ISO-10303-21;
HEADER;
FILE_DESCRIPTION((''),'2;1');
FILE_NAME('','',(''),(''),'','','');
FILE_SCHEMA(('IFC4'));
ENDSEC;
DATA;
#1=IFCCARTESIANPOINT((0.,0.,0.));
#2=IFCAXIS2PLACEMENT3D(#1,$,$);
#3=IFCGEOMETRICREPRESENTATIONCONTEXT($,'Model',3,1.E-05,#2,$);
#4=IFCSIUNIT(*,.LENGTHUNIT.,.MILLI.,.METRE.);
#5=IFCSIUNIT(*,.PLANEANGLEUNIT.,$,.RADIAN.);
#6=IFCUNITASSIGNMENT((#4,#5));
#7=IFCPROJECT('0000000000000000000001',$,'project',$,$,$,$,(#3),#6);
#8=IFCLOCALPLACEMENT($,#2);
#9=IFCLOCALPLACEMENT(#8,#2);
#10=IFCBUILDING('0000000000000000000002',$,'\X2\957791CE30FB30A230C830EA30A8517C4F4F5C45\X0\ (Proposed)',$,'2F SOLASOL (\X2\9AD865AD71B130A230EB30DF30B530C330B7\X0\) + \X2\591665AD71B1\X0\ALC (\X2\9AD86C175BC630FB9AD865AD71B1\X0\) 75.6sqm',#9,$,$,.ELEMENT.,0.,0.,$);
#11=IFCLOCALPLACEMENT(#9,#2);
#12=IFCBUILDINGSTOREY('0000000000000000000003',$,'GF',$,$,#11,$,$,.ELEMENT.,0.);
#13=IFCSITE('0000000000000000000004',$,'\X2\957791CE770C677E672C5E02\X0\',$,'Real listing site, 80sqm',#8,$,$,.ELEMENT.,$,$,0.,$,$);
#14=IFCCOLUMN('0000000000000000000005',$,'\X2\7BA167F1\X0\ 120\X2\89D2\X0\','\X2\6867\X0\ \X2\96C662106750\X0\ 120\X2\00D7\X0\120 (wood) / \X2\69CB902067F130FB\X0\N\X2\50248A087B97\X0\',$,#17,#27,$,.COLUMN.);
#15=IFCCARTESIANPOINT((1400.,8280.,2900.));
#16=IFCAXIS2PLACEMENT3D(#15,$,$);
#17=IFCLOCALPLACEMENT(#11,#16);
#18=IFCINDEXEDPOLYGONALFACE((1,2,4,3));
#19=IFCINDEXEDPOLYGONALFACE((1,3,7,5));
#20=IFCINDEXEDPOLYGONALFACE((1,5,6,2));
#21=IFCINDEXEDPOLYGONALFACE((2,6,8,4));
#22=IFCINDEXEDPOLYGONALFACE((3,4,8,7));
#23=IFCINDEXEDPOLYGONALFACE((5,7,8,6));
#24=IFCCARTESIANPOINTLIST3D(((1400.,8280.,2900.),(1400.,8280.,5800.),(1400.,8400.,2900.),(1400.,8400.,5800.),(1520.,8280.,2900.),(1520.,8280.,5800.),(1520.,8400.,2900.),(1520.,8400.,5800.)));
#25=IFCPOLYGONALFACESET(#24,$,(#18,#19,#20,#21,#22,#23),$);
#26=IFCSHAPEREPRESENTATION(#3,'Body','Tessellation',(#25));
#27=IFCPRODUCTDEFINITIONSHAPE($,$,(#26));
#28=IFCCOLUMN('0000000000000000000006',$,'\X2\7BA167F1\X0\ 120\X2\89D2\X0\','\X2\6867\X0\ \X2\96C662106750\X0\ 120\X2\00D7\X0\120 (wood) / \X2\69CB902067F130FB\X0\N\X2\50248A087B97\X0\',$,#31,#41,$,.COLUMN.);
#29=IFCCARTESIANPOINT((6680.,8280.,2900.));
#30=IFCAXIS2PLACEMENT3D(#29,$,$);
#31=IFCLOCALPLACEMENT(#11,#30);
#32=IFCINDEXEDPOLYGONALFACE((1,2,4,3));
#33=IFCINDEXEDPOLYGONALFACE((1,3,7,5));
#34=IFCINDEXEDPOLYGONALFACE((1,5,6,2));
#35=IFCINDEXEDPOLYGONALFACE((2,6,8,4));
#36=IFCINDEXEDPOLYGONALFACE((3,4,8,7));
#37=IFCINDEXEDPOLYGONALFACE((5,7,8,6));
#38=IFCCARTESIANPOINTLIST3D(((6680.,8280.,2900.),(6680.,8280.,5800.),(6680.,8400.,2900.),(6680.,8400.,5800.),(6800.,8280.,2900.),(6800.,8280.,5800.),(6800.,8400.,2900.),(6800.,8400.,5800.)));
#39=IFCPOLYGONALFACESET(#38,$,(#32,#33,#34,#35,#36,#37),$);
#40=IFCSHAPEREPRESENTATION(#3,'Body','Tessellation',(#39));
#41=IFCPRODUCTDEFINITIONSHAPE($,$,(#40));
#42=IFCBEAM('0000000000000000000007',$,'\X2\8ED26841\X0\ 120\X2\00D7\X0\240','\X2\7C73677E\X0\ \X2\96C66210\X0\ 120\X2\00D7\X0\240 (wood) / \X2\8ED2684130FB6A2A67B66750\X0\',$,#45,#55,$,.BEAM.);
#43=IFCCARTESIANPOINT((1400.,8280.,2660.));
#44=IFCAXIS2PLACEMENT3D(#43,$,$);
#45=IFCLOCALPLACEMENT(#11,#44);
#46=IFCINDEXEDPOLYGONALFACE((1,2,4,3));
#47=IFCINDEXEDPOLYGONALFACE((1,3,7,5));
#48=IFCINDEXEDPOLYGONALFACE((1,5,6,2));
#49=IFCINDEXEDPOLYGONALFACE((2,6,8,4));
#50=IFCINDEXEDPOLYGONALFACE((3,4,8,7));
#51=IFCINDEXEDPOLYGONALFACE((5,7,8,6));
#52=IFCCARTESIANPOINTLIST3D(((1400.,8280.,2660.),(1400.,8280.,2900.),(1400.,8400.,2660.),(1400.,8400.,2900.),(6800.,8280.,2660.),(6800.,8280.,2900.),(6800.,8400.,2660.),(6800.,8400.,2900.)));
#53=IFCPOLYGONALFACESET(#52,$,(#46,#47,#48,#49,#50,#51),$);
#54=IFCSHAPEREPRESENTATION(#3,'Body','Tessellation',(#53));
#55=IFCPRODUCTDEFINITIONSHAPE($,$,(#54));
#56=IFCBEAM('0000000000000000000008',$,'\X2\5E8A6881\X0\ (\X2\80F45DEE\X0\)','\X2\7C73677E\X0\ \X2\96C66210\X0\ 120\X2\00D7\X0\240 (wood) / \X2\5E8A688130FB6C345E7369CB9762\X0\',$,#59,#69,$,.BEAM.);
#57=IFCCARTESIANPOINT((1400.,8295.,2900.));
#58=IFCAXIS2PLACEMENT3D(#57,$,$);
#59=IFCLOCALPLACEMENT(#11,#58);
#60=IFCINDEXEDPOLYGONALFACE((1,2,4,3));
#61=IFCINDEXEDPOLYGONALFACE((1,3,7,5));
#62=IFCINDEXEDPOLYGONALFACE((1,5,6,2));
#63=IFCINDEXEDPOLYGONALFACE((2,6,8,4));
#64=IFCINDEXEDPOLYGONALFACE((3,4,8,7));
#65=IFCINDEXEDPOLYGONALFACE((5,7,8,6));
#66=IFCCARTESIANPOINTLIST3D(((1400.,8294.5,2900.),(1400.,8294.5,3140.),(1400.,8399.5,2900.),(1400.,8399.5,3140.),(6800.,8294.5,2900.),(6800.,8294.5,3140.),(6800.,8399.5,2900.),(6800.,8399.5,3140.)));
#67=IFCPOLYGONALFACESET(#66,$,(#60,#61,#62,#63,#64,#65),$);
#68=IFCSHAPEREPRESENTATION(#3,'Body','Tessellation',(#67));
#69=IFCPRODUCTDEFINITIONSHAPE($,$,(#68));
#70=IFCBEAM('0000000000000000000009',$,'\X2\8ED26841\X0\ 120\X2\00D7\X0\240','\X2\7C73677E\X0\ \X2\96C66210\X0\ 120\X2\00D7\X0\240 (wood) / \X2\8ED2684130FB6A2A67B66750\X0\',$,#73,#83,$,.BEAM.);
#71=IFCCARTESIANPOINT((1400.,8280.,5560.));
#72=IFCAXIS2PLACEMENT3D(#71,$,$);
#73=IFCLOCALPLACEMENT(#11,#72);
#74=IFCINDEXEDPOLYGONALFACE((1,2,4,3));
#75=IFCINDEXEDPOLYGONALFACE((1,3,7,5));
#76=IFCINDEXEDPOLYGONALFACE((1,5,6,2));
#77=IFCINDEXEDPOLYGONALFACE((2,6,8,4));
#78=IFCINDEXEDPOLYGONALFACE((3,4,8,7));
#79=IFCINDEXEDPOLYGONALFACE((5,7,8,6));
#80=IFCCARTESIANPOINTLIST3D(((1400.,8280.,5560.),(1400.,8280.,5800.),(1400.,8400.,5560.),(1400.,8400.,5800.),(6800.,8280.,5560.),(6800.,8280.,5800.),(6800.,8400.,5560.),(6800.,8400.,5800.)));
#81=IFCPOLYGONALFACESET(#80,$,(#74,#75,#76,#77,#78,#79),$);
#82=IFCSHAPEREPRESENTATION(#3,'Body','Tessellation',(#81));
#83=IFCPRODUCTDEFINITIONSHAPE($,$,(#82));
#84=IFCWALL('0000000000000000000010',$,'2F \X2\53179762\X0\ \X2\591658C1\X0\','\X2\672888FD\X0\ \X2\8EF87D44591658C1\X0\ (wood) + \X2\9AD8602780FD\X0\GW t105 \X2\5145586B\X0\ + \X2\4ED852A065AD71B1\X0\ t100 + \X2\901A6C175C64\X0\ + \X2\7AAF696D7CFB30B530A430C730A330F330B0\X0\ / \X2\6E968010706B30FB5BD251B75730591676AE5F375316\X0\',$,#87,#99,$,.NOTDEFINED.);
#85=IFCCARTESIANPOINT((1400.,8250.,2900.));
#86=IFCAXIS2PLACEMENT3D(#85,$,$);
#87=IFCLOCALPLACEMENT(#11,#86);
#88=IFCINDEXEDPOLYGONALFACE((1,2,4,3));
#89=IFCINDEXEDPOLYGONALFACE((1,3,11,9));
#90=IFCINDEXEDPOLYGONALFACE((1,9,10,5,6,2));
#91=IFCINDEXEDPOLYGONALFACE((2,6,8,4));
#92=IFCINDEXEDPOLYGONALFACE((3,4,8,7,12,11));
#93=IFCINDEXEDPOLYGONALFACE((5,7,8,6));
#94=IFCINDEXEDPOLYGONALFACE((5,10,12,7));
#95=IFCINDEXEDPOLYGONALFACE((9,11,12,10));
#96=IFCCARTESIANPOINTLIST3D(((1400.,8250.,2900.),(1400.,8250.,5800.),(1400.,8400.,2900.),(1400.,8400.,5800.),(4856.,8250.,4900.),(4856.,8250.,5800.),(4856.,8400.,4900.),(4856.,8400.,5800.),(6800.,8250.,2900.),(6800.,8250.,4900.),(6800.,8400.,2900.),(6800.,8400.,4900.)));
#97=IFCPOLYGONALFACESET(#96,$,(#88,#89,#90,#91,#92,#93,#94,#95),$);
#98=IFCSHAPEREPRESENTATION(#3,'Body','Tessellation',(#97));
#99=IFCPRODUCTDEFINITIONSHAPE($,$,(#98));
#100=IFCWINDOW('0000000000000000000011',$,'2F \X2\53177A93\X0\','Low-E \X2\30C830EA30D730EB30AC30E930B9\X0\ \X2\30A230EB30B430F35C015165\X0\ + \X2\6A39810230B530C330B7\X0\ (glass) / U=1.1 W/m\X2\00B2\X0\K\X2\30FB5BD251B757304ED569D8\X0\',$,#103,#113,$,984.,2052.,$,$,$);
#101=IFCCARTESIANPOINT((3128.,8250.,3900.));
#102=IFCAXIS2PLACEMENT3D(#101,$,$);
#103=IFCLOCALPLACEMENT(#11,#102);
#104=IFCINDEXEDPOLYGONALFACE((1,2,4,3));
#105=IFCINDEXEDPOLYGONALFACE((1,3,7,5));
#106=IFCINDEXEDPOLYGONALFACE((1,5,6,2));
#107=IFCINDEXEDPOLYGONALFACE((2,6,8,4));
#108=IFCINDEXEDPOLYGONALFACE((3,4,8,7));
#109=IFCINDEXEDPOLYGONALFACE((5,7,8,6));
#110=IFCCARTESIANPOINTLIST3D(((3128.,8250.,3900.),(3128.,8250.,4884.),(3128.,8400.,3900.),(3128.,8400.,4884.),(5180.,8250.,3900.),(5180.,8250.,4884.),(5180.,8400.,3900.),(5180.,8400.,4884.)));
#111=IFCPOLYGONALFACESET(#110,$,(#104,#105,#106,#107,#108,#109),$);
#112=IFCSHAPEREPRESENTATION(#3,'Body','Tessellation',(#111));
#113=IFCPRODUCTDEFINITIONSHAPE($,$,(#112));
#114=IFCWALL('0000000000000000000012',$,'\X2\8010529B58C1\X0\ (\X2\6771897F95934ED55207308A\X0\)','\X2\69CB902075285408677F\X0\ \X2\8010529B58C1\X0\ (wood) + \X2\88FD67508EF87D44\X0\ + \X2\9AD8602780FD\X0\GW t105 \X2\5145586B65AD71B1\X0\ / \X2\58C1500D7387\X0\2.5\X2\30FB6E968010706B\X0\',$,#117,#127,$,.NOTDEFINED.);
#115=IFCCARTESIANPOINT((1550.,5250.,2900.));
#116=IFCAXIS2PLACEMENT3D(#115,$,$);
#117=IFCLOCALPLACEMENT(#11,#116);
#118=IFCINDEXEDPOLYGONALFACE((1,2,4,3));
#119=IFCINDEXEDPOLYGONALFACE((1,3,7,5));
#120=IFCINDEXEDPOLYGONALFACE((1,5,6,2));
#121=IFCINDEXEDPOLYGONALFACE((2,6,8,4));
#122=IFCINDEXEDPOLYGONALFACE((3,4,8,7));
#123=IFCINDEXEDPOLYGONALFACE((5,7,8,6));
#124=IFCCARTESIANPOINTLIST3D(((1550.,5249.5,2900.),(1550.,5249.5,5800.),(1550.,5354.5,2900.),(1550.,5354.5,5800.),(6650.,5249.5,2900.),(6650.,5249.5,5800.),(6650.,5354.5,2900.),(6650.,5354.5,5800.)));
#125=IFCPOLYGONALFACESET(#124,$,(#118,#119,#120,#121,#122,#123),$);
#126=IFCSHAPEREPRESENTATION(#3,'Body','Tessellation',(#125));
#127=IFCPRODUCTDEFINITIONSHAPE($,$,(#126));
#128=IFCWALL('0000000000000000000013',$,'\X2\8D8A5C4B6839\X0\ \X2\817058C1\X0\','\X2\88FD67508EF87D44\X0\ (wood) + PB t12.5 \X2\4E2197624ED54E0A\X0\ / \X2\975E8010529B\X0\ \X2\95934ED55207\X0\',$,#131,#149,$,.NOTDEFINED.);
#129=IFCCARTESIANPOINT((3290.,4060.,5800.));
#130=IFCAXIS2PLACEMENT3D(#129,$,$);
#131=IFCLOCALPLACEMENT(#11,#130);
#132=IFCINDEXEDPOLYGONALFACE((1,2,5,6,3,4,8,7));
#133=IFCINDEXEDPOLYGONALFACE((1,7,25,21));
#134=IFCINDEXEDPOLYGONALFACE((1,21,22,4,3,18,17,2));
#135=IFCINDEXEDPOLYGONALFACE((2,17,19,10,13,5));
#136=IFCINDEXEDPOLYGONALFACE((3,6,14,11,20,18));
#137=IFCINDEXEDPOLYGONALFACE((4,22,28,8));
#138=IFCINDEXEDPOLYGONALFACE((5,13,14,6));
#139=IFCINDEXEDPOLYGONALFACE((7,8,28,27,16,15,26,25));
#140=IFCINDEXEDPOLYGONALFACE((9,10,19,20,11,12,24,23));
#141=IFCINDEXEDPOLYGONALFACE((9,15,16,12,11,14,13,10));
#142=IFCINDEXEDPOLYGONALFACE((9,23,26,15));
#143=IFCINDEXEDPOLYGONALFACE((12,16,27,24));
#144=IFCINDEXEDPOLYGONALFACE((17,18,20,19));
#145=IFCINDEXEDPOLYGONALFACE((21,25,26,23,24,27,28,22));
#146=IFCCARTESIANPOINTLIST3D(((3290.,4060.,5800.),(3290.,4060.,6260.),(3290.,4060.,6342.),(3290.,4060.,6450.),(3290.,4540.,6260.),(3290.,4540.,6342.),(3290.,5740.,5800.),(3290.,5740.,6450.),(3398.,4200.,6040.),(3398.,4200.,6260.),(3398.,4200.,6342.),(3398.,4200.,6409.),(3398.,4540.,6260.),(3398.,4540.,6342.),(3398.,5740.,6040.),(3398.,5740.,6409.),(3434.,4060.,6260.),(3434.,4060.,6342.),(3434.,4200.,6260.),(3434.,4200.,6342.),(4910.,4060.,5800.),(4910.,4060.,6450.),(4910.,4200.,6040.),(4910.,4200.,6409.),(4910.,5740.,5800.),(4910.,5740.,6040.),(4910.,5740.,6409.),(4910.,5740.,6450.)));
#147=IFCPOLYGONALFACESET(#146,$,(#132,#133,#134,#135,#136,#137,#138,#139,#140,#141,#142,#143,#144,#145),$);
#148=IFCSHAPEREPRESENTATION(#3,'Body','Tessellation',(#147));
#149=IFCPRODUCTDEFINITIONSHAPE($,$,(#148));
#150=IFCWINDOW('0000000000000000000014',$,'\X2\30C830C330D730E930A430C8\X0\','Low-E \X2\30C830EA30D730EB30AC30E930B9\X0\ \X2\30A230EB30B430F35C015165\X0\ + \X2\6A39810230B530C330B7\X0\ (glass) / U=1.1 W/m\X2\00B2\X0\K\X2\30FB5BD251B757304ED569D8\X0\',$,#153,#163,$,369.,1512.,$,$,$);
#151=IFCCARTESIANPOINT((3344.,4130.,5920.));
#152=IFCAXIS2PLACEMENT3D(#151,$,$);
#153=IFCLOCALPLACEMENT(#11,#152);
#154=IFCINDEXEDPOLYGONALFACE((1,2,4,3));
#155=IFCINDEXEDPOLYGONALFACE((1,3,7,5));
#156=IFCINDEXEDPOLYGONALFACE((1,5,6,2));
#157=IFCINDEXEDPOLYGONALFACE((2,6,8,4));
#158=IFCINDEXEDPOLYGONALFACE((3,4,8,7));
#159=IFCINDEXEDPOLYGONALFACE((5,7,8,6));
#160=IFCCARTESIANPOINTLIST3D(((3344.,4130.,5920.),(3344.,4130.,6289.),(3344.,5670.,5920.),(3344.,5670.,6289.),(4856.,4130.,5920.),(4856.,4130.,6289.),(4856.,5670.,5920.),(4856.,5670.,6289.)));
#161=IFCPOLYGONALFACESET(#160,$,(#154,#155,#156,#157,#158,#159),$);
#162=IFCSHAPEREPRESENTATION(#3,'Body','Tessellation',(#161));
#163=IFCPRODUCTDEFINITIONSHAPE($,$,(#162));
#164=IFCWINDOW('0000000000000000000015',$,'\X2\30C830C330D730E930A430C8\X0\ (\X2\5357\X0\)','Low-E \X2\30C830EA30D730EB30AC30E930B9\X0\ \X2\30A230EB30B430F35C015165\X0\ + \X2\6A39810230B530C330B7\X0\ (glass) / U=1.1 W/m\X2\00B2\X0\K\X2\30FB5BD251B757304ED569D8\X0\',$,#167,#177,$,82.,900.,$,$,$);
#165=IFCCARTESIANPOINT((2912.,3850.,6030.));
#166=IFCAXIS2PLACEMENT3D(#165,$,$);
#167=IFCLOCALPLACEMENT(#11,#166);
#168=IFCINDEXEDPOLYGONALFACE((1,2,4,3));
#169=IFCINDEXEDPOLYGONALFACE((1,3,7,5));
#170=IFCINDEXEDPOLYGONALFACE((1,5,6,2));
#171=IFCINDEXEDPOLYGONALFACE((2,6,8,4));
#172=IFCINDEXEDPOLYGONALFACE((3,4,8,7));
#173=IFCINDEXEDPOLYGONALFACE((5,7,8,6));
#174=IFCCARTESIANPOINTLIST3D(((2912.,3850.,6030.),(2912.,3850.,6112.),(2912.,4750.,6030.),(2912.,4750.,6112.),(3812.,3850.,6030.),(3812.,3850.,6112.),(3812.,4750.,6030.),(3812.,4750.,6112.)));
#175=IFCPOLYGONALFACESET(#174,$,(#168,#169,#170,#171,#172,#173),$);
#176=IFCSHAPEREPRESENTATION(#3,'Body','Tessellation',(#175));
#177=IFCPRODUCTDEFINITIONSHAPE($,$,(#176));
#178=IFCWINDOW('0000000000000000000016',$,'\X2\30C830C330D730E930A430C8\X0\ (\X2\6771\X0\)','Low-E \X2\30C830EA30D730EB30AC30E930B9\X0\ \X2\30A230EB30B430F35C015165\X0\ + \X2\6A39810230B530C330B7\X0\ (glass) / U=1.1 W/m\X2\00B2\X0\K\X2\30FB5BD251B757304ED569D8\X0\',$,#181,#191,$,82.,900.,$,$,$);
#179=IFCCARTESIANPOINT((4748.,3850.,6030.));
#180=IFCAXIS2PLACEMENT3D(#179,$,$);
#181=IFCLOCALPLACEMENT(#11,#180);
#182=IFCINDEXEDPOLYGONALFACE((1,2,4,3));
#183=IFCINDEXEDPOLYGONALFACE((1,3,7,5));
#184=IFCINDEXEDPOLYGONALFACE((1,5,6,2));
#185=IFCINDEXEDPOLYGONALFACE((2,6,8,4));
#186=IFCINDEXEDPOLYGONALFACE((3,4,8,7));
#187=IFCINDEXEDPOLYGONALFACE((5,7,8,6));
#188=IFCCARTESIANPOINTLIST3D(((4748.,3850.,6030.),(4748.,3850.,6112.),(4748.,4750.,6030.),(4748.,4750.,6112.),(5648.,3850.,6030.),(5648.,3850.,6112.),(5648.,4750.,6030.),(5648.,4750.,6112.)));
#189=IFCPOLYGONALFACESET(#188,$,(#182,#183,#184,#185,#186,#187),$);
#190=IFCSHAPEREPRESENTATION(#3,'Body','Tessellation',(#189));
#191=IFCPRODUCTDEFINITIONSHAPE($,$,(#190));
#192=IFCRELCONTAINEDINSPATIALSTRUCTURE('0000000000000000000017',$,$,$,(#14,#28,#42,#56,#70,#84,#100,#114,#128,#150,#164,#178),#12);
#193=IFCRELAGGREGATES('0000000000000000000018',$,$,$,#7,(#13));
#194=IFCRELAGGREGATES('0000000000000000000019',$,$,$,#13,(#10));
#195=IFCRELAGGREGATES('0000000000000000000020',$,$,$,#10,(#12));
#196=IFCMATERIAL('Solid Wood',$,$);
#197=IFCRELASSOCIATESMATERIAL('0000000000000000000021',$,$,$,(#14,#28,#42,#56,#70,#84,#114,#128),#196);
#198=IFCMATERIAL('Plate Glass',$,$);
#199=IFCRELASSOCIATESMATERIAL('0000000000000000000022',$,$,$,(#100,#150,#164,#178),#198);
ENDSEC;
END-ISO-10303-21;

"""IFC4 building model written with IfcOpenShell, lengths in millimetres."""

from ifc_helpers import new_model, si_unit, frame, frame_2d, origin, place, context, project, spatial, rectangle, extrude, material, element, fill, save


model = new_model("IFC4")

# Units and contexts
model_context = context("Model", 3, precision=1e-05, world=origin())
ifc_project = project(units=[si_unit("LENGTHUNIT", "METRE", prefix="MILLI"), si_unit("PLANEANGLEUNIT", "RADIAN")], contexts=[model_context])

# Site, building, storey
site_placement = place(None, origin())
site = spatial("IfcSite", under=ifc_project, at=site_placement, Name="長野県松本市", ObjectType="Real listing site, 80sqm", CompositionType="ELEMENT", RefElevation=0.0)
building_placement = place(site_placement, origin())
building = spatial("IfcBuilding", under=site, at=building_placement, Name="長野・アトリエ兼住居 (Proposed)", ObjectType="2F SOLASOL (高断熱アルミサッシ) + 外断熱ALC (高気密・高断熱) 75.6sqm", CompositionType="ELEMENT", ElevationOfRefHeight=0.0, ElevationOfTerrain=0.0)
storey_placement = place(building_placement, origin())
storey = spatial("IfcBuildingStorey", under=building, at=storey_placement, Name="GF", CompositionType="ELEMENT", Elevation=0.0)

# Columns
ifc_material_1 = material(Name="Solid Wood")
column_1_placement = place(storey_placement, frame((1400.0, 8280.0, 2900.0)))
element("IfcColumn", 1, at=column_1_placement, inside=storey, material=ifc_material_1, Name="管柱 120角", Description="桧 集成材 120×120 (wood) / 構造柱・N値計算", PredefinedType="COLUMN", context=model_context, shape_type="SweptSolid", body=[
    extrude(rectangle(XDim=120.0, YDim=120.0, at=frame_2d((60.0, 60.0))), frame((1400.0, 8280.0, 2900.0)), (0.0, 0.0, 1.0), 2900.0),
])
column_2_placement = place(storey_placement, frame((6680.0, 8280.0, 2900.0)))
element("IfcColumn", 2, at=column_2_placement, inside=storey, material=ifc_material_1, Name="管柱 120角", Description="桧 集成材 120×120 (wood) / 構造柱・N値計算", PredefinedType="COLUMN", context=model_context, shape_type="SweptSolid", body=[
    extrude(rectangle(XDim=120.0, YDim=120.0, at=frame_2d((60.0, 60.0))), frame((6680.0, 8280.0, 2900.0)), (0.0, 0.0, 1.0), 2900.0),
])

# Beams
beam_1_placement = place(storey_placement, frame((1400.0, 8280.0, 2660.0)))
element("IfcBeam", 3, at=beam_1_placement, inside=storey, material=ifc_material_1, Name="軒桁 120×240", Description="米松 集成 120×240 (wood) / 軒桁・横架材", PredefinedType="BEAM", context=model_context, shape_type="SweptSolid", body=[
    extrude(rectangle(XDim=5400.0, YDim=120.0, at=frame_2d((2700.0, 60.0))), frame((1400.0, 8280.0, 2660.0)), (0.0, 0.0, 1.0), 240.0),
])
beam_2_placement = place(storey_placement, frame((1400.0, 8295.0, 2900.0)))
element("IfcBeam", 4, at=beam_2_placement, inside=storey, material=ifc_material_1, Name="床梁 (胴差)", Description="米松 集成 120×240 (wood) / 床梁・水平構面", PredefinedType="BEAM", context=model_context, shape_type="SweptSolid", body=[
    extrude(rectangle(XDim=5400.0, YDim=105.0, at=frame_2d((2700.0, 52.0))), frame((1400.0, 8295.0, 2900.0)), (0.0, 0.0, 1.0), 240.0),
])
beam_3_placement = place(storey_placement, frame((1400.0, 8280.0, 5560.0)))
element("IfcBeam", 5, at=beam_3_placement, inside=storey, material=ifc_material_1, Name="軒桁 120×240", Description="米松 集成 120×240 (wood) / 軒桁・横架材", PredefinedType="BEAM", context=model_context, shape_type="SweptSolid", body=[
    extrude(rectangle(XDim=5400.0, YDim=120.0, at=frame_2d((2700.0, 60.0))), frame((1400.0, 8280.0, 5560.0)), (0.0, 0.0, 1.0), 240.0),
])

# Wall, opening, window
wall_1_placement = place(storey_placement, frame((1400.0, 8250.0, 2900.0)))
wall_1 = element("IfcWall", 6, at=wall_1_placement, inside=storey, material=ifc_material_1, Name="2F 北面 外壁", Description="木製 軸組外壁 (wood) + 高性能GW t105 充填 + 付加断熱 t100 + 通気層 + 窯業系サイディング / 準耐火・寒冷地外皮強化", PredefinedType="NOTDEFINED", context=model_context, shape_type="SweptSolid", body=[
    extrude(rectangle(XDim=5400.0, YDim=150.0, at=frame_2d((2700.0, 75.0))), frame((1400.0, 8250.0, 2900.0)), (0.0, 0.0, 1.0), 2900.0),
])
opening_1_placement = place(storey_placement, frame((3128.0, 8250.0, 3900.0)))
opening_1 = element("IfcOpeningElement", 7, at=opening_1_placement, cuts=wall_1, PredefinedType="NOTDEFINED", context=model_context, shape_type="SweptSolid", body=[
    extrude(rectangle(XDim=2052.0, YDim=150.0, at=frame_2d((1026.0, 75.0))), frame((3128.0, 8250.0, 3900.0)), (0.0, 0.0, 1.0), 984.0),
])
ifc_material_2 = material(Name="Plate Glass")
window_1_placement = place(storey_placement, frame((3128.0, 8250.0, 3900.0)))
window_1 = element("IfcWindow", 8, at=window_1_placement, inside=storey, material=ifc_material_2, Name="2F 北窓", Description="Low-E トリプルガラス アルゴン封入 + 樹脂サッシ (glass) / U=1.1 W/m²K・寒冷地仕様", OverallHeight=984.0, OverallWidth=2052.0, context=model_context, shape_type="SweptSolid", body=[
    extrude(rectangle(XDim=2052.0, YDim=150.0, at=frame_2d((1026.0, 75.0))), frame((3128.0, 8250.0, 3900.0)), (0.0, 0.0, 1.0), 984.0),
])
fill(opening_1, window_1)

# Wall
wall_2_placement = place(storey_placement, frame((1550.0, 5250.0, 2900.0)))
element("IfcWall", 9, at=wall_2_placement, inside=storey, material=ifc_material_1, Name="耐力壁 (東西間仕切り)", Description="構造用合板 耐力壁 (wood) + 製材軸組 + 高性能GW t105 充填断熱 / 壁倍率2.5・準耐火", PredefinedType="NOTDEFINED", context=model_context, shape_type="SweptSolid", body=[
    extrude(rectangle(XDim=5100.0, YDim=105.0, at=frame_2d((2550.0, 52.0))), frame((1550.0, 5250.0, 2900.0)), (0.0, 0.0, 1.0), 2900.0),
])

# Wall, openings, windows
wall_3_placement = place(storey_placement, frame((3290.0, 4060.0, 5800.0)))
wall_3 = element("IfcWall", 10, at=wall_3_placement, inside=storey, material=ifc_material_1, Name="越屋根 腰壁", Description="製材軸組 (wood) + PB t12.5 両面仕上 / 非耐力 間仕切", PredefinedType="NOTDEFINED", context=model_context, shape_type="SweptSolid", body=[
    extrude(rectangle(XDim=1620.0, YDim=1680.0, at=frame_2d((810.0, 840.0))), frame((3290.0, 4060.0, 5800.0)), (0.0, 0.0, 1.0), 650.0),
])
opening_2_placement = place(storey_placement, frame((3344.0, 4130.0, 5920.0)))
opening_2 = element("IfcOpeningElement", 11, at=opening_2_placement, cuts=wall_3, PredefinedType="NOTDEFINED", context=model_context, shape_type="SweptSolid", body=[
    extrude(rectangle(XDim=1512.0, YDim=1540.0, at=frame_2d((756.0, 770.0))), frame((3344.0, 4130.0, 5920.0)), (0.0, 0.0, 1.0), 369.0),
])
opening_3_placement = place(storey_placement, frame((2912.0, 3850.0, 6030.0)))
opening_3 = element("IfcOpeningElement", 12, at=opening_3_placement, cuts=wall_3, PredefinedType="NOTDEFINED", context=model_context, shape_type="SweptSolid", body=[
    extrude(rectangle(XDim=900.0, YDim=900.0, at=frame_2d((450.0, 450.0))), frame((2912.0, 3850.0, 6030.0)), (0.0, 0.0, 1.0), 82.0),
])
opening_4_placement = place(storey_placement, frame((4748.0, 3850.0, 6030.0)))
opening_4 = element("IfcOpeningElement", 13, at=opening_4_placement, cuts=wall_3, PredefinedType="NOTDEFINED", context=model_context, shape_type="SweptSolid", body=[
    extrude(rectangle(XDim=900.0, YDim=900.0, at=frame_2d((450.0, 450.0))), frame((4748.0, 3850.0, 6030.0)), (0.0, 0.0, 1.0), 82.0),
])
window_2_placement = place(storey_placement, frame((3344.0, 4130.0, 5920.0)))
window_2 = element("IfcWindow", 14, at=window_2_placement, inside=storey, material=ifc_material_2, Name="トップライト", Description="Low-E トリプルガラス アルゴン封入 + 樹脂サッシ (glass) / U=1.1 W/m²K・寒冷地仕様", OverallHeight=369.0, OverallWidth=1512.0, context=model_context, shape_type="SweptSolid", body=[
    extrude(rectangle(XDim=1512.0, YDim=1540.0, at=frame_2d((756.0, 770.0))), frame((3344.0, 4130.0, 5920.0)), (0.0, 0.0, 1.0), 369.0),
])
fill(opening_2, window_2)
window_3_placement = place(storey_placement, frame((2912.0, 3850.0, 6030.0)))
window_3 = element("IfcWindow", 15, at=window_3_placement, inside=storey, material=ifc_material_2, Name="トップライト (南)", Description="Low-E トリプルガラス アルゴン封入 + 樹脂サッシ (glass) / U=1.1 W/m²K・寒冷地仕様", OverallHeight=82.0, OverallWidth=900.0, context=model_context, shape_type="SweptSolid", body=[
    extrude(rectangle(XDim=900.0, YDim=900.0, at=frame_2d((450.0, 450.0))), frame((2912.0, 3850.0, 6030.0)), (0.0, 0.0, 1.0), 82.0),
])
fill(opening_3, window_3)
window_4_placement = place(storey_placement, frame((4748.0, 3850.0, 6030.0)))
window_4 = element("IfcWindow", 16, at=window_4_placement, inside=storey, material=ifc_material_2, Name="トップライト (東)", Description="Low-E トリプルガラス アルゴン封入 + 樹脂サッシ (glass) / U=1.1 W/m²K・寒冷地仕様", OverallHeight=82.0, OverallWidth=900.0, context=model_context, shape_type="SweptSolid", body=[
    extrude(rectangle(XDim=900.0, YDim=900.0, at=frame_2d((450.0, 450.0))), frame((4748.0, 3850.0, 6030.0)), (0.0, 0.0, 1.0), 82.0),
])
fill(opening_4, window_4)

save(model, "model.ifc")
